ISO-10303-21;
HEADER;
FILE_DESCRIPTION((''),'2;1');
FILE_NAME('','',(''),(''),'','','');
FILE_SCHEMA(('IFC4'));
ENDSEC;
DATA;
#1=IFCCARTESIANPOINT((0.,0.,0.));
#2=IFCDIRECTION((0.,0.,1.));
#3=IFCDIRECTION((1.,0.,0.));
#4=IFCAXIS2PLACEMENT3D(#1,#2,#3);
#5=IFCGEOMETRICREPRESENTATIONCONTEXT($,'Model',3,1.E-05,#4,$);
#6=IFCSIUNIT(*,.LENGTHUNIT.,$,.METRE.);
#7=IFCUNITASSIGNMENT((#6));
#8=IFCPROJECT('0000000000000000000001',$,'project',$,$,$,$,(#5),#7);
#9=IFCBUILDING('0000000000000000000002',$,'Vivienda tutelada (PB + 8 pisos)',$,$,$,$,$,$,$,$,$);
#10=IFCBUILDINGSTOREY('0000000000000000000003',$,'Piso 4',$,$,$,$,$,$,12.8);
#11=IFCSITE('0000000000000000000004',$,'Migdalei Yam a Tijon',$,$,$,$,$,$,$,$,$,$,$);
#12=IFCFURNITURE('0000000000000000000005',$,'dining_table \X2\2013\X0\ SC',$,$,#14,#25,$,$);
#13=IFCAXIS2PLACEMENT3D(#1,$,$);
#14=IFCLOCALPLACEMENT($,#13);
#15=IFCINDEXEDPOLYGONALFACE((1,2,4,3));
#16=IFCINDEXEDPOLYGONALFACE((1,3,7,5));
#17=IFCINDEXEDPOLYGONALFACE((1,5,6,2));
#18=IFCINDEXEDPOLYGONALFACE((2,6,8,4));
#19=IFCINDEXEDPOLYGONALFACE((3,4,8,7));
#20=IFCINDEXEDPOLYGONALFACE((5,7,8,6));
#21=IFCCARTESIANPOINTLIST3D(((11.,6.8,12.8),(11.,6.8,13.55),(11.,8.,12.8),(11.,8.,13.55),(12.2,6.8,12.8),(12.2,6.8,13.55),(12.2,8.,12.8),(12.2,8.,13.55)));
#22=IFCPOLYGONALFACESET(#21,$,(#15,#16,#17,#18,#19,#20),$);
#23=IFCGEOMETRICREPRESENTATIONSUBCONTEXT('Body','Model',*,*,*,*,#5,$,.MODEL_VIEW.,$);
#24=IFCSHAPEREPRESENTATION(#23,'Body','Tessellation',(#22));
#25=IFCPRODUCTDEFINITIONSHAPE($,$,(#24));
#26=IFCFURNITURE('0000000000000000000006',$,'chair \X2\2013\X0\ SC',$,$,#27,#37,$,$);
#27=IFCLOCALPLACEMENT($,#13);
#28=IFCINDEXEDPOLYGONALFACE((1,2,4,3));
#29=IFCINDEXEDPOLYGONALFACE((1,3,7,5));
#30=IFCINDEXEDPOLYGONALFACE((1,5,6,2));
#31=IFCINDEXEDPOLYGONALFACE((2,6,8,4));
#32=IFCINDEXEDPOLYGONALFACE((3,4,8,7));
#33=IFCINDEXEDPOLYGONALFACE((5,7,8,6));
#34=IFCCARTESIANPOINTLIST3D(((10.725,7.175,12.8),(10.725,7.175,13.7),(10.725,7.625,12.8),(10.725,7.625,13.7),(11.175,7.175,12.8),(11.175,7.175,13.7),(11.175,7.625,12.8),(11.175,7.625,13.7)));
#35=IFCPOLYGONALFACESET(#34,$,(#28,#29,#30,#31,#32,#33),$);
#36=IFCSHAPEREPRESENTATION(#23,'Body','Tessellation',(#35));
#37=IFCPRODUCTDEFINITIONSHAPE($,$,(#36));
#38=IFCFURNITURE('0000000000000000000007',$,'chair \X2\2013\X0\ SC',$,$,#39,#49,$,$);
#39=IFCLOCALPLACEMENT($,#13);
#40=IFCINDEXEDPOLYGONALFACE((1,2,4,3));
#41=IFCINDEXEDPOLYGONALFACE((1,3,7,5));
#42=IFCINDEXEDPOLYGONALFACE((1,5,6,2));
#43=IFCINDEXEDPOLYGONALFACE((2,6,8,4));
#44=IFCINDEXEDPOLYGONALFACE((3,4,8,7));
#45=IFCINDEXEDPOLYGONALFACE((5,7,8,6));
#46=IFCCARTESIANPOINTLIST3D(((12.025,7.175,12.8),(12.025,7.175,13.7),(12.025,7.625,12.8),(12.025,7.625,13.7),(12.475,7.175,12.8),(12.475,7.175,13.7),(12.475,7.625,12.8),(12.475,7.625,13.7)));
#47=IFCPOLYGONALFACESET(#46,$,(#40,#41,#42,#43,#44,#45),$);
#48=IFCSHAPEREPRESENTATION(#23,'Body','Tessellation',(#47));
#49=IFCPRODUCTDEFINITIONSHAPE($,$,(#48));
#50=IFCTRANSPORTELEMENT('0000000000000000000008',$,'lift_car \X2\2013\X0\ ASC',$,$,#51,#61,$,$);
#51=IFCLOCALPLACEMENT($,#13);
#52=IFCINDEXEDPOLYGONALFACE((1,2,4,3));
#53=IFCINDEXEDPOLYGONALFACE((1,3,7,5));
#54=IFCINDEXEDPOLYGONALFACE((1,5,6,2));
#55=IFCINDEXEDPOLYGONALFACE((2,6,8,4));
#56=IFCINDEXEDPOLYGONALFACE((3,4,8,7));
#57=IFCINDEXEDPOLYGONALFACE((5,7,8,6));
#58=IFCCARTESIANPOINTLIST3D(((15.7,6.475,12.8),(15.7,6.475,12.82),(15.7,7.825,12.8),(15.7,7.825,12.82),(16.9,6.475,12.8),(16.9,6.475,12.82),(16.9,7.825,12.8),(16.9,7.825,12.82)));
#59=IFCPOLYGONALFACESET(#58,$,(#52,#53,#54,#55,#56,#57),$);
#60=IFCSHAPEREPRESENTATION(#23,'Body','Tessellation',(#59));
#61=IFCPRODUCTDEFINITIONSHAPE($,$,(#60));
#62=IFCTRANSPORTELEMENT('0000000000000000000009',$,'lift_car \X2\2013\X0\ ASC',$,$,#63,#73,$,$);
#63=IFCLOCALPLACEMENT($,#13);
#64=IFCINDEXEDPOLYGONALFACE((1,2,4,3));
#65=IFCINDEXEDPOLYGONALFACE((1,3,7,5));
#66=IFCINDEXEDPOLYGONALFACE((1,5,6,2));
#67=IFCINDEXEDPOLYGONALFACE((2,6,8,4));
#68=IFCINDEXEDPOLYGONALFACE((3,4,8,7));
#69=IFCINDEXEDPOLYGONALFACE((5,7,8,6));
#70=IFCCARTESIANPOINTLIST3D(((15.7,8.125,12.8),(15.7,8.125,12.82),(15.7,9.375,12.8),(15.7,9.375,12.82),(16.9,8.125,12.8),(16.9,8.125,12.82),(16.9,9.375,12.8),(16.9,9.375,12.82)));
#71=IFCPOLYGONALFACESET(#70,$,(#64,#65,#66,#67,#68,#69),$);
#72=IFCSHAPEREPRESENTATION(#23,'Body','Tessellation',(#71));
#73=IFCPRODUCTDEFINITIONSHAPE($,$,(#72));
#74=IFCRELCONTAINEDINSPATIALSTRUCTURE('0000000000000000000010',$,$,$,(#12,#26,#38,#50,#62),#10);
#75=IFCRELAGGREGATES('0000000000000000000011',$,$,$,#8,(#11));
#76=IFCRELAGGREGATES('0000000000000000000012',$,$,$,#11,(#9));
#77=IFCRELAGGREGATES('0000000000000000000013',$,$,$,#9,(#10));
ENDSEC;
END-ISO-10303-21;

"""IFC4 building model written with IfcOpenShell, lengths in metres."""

from ifc_helpers import new_model, si_unit, frame, origin_with_axes, context, subcontext, project, spatial, line, indexed_curve, outline, extrude, element, save


model = new_model("IFC4")

# Units and contexts
model_context = context("Model", 3, precision=1e-05, world=origin_with_axes())
body_context = subcontext(model_context, "Body", "Model", "MODEL_VIEW")
ifc_project = project(units=[si_unit("LENGTHUNIT", "METRE")], contexts=[model_context])

# Site, building, storey
site = spatial("IfcSite", under=ifc_project, Name="Migdalei Yam a Tijon")
building = spatial("IfcBuilding", under=site, Name="Vivienda tutelada (PB + 8 pisos)")
storey = spatial("IfcBuildingStorey", under=building, Name="Piso 4", Elevation=12.8)

# Furniture
element("IfcFurniture", 1, inside=storey, Name="dining_table – SC", context=body_context, shape_type="SweptSolid", body=[
    extrude(outline(indexed_curve([(0.0, 0.0), (1.2, 0.0), (1.2, 1.2), (0.0, 1.2)], segments=[line(1, 2, 3, 4, 1)])), frame((11.0, 6.8, 12.8), z_axis=(0.0, 0.0, 1.0), x_axis=(1.0, 0.0, 0.0)), (0.0, 0.0, 1.0), 0.75),
])
element("IfcFurniture", 2, inside=storey, Name="chair – SC", context=body_context, shape_type="SweptSolid", body=[
    extrude(outline(indexed_curve([(0.0, 0.0), (0.45, 0.0), (0.45, 0.45), (0.0, 0.45)], segments=[line(1, 2, 3, 4, 1)])), frame((10.725, 7.175, 12.8), z_axis=(0.0, 0.0, 1.0), x_axis=(1.0, 0.0, 0.0)), (0.0, 0.0, 1.0), 0.9),
])
element("IfcFurniture", 3, inside=storey, Name="chair – SC", context=body_context, shape_type="SweptSolid", body=[
    extrude(outline(indexed_curve([(0.0, 0.0), (0.45, 0.0), (0.45, 0.45), (0.0, 0.45)], segments=[line(1, 2, 3, 4, 1)])), frame((12.025, 7.175, 12.8), z_axis=(0.0, 0.0, 1.0), x_axis=(1.0, 0.0, 0.0)), (0.0, 0.0, 1.0), 0.9),
])

# Transport elements
element("IfcTransportElement", 4, inside=storey, Name="lift_car – ASC", context=body_context, shape_type="SweptSolid", body=[
    extrude(outline(indexed_curve([(0.0, 0.0), (1.2, 0.0), (1.2, 1.35), (0.0, 1.35)], segments=[line(1, 2, 3, 4, 1)])), frame((15.7, 6.475, 12.8), z_axis=(0.0, 0.0, 1.0), x_axis=(1.0, 0.0, 0.0)), (0.0, 0.0, 1.0), 0.02),
])
element("IfcTransportElement", 5, inside=storey, Name="lift_car – ASC", context=body_context, shape_type="SweptSolid", body=[
    extrude(outline(indexed_curve([(0.0, 0.0), (1.2, 0.0), (1.2, 1.25), (0.0, 1.25)], segments=[line(1, 2, 3, 4, 1)])), frame((15.7, 8.125, 12.8), z_axis=(0.0, 0.0, 1.0), x_axis=(1.0, 0.0, 0.0)), (0.0, 0.0, 1.0), 0.02),
])

save(model, "model.ifc")
